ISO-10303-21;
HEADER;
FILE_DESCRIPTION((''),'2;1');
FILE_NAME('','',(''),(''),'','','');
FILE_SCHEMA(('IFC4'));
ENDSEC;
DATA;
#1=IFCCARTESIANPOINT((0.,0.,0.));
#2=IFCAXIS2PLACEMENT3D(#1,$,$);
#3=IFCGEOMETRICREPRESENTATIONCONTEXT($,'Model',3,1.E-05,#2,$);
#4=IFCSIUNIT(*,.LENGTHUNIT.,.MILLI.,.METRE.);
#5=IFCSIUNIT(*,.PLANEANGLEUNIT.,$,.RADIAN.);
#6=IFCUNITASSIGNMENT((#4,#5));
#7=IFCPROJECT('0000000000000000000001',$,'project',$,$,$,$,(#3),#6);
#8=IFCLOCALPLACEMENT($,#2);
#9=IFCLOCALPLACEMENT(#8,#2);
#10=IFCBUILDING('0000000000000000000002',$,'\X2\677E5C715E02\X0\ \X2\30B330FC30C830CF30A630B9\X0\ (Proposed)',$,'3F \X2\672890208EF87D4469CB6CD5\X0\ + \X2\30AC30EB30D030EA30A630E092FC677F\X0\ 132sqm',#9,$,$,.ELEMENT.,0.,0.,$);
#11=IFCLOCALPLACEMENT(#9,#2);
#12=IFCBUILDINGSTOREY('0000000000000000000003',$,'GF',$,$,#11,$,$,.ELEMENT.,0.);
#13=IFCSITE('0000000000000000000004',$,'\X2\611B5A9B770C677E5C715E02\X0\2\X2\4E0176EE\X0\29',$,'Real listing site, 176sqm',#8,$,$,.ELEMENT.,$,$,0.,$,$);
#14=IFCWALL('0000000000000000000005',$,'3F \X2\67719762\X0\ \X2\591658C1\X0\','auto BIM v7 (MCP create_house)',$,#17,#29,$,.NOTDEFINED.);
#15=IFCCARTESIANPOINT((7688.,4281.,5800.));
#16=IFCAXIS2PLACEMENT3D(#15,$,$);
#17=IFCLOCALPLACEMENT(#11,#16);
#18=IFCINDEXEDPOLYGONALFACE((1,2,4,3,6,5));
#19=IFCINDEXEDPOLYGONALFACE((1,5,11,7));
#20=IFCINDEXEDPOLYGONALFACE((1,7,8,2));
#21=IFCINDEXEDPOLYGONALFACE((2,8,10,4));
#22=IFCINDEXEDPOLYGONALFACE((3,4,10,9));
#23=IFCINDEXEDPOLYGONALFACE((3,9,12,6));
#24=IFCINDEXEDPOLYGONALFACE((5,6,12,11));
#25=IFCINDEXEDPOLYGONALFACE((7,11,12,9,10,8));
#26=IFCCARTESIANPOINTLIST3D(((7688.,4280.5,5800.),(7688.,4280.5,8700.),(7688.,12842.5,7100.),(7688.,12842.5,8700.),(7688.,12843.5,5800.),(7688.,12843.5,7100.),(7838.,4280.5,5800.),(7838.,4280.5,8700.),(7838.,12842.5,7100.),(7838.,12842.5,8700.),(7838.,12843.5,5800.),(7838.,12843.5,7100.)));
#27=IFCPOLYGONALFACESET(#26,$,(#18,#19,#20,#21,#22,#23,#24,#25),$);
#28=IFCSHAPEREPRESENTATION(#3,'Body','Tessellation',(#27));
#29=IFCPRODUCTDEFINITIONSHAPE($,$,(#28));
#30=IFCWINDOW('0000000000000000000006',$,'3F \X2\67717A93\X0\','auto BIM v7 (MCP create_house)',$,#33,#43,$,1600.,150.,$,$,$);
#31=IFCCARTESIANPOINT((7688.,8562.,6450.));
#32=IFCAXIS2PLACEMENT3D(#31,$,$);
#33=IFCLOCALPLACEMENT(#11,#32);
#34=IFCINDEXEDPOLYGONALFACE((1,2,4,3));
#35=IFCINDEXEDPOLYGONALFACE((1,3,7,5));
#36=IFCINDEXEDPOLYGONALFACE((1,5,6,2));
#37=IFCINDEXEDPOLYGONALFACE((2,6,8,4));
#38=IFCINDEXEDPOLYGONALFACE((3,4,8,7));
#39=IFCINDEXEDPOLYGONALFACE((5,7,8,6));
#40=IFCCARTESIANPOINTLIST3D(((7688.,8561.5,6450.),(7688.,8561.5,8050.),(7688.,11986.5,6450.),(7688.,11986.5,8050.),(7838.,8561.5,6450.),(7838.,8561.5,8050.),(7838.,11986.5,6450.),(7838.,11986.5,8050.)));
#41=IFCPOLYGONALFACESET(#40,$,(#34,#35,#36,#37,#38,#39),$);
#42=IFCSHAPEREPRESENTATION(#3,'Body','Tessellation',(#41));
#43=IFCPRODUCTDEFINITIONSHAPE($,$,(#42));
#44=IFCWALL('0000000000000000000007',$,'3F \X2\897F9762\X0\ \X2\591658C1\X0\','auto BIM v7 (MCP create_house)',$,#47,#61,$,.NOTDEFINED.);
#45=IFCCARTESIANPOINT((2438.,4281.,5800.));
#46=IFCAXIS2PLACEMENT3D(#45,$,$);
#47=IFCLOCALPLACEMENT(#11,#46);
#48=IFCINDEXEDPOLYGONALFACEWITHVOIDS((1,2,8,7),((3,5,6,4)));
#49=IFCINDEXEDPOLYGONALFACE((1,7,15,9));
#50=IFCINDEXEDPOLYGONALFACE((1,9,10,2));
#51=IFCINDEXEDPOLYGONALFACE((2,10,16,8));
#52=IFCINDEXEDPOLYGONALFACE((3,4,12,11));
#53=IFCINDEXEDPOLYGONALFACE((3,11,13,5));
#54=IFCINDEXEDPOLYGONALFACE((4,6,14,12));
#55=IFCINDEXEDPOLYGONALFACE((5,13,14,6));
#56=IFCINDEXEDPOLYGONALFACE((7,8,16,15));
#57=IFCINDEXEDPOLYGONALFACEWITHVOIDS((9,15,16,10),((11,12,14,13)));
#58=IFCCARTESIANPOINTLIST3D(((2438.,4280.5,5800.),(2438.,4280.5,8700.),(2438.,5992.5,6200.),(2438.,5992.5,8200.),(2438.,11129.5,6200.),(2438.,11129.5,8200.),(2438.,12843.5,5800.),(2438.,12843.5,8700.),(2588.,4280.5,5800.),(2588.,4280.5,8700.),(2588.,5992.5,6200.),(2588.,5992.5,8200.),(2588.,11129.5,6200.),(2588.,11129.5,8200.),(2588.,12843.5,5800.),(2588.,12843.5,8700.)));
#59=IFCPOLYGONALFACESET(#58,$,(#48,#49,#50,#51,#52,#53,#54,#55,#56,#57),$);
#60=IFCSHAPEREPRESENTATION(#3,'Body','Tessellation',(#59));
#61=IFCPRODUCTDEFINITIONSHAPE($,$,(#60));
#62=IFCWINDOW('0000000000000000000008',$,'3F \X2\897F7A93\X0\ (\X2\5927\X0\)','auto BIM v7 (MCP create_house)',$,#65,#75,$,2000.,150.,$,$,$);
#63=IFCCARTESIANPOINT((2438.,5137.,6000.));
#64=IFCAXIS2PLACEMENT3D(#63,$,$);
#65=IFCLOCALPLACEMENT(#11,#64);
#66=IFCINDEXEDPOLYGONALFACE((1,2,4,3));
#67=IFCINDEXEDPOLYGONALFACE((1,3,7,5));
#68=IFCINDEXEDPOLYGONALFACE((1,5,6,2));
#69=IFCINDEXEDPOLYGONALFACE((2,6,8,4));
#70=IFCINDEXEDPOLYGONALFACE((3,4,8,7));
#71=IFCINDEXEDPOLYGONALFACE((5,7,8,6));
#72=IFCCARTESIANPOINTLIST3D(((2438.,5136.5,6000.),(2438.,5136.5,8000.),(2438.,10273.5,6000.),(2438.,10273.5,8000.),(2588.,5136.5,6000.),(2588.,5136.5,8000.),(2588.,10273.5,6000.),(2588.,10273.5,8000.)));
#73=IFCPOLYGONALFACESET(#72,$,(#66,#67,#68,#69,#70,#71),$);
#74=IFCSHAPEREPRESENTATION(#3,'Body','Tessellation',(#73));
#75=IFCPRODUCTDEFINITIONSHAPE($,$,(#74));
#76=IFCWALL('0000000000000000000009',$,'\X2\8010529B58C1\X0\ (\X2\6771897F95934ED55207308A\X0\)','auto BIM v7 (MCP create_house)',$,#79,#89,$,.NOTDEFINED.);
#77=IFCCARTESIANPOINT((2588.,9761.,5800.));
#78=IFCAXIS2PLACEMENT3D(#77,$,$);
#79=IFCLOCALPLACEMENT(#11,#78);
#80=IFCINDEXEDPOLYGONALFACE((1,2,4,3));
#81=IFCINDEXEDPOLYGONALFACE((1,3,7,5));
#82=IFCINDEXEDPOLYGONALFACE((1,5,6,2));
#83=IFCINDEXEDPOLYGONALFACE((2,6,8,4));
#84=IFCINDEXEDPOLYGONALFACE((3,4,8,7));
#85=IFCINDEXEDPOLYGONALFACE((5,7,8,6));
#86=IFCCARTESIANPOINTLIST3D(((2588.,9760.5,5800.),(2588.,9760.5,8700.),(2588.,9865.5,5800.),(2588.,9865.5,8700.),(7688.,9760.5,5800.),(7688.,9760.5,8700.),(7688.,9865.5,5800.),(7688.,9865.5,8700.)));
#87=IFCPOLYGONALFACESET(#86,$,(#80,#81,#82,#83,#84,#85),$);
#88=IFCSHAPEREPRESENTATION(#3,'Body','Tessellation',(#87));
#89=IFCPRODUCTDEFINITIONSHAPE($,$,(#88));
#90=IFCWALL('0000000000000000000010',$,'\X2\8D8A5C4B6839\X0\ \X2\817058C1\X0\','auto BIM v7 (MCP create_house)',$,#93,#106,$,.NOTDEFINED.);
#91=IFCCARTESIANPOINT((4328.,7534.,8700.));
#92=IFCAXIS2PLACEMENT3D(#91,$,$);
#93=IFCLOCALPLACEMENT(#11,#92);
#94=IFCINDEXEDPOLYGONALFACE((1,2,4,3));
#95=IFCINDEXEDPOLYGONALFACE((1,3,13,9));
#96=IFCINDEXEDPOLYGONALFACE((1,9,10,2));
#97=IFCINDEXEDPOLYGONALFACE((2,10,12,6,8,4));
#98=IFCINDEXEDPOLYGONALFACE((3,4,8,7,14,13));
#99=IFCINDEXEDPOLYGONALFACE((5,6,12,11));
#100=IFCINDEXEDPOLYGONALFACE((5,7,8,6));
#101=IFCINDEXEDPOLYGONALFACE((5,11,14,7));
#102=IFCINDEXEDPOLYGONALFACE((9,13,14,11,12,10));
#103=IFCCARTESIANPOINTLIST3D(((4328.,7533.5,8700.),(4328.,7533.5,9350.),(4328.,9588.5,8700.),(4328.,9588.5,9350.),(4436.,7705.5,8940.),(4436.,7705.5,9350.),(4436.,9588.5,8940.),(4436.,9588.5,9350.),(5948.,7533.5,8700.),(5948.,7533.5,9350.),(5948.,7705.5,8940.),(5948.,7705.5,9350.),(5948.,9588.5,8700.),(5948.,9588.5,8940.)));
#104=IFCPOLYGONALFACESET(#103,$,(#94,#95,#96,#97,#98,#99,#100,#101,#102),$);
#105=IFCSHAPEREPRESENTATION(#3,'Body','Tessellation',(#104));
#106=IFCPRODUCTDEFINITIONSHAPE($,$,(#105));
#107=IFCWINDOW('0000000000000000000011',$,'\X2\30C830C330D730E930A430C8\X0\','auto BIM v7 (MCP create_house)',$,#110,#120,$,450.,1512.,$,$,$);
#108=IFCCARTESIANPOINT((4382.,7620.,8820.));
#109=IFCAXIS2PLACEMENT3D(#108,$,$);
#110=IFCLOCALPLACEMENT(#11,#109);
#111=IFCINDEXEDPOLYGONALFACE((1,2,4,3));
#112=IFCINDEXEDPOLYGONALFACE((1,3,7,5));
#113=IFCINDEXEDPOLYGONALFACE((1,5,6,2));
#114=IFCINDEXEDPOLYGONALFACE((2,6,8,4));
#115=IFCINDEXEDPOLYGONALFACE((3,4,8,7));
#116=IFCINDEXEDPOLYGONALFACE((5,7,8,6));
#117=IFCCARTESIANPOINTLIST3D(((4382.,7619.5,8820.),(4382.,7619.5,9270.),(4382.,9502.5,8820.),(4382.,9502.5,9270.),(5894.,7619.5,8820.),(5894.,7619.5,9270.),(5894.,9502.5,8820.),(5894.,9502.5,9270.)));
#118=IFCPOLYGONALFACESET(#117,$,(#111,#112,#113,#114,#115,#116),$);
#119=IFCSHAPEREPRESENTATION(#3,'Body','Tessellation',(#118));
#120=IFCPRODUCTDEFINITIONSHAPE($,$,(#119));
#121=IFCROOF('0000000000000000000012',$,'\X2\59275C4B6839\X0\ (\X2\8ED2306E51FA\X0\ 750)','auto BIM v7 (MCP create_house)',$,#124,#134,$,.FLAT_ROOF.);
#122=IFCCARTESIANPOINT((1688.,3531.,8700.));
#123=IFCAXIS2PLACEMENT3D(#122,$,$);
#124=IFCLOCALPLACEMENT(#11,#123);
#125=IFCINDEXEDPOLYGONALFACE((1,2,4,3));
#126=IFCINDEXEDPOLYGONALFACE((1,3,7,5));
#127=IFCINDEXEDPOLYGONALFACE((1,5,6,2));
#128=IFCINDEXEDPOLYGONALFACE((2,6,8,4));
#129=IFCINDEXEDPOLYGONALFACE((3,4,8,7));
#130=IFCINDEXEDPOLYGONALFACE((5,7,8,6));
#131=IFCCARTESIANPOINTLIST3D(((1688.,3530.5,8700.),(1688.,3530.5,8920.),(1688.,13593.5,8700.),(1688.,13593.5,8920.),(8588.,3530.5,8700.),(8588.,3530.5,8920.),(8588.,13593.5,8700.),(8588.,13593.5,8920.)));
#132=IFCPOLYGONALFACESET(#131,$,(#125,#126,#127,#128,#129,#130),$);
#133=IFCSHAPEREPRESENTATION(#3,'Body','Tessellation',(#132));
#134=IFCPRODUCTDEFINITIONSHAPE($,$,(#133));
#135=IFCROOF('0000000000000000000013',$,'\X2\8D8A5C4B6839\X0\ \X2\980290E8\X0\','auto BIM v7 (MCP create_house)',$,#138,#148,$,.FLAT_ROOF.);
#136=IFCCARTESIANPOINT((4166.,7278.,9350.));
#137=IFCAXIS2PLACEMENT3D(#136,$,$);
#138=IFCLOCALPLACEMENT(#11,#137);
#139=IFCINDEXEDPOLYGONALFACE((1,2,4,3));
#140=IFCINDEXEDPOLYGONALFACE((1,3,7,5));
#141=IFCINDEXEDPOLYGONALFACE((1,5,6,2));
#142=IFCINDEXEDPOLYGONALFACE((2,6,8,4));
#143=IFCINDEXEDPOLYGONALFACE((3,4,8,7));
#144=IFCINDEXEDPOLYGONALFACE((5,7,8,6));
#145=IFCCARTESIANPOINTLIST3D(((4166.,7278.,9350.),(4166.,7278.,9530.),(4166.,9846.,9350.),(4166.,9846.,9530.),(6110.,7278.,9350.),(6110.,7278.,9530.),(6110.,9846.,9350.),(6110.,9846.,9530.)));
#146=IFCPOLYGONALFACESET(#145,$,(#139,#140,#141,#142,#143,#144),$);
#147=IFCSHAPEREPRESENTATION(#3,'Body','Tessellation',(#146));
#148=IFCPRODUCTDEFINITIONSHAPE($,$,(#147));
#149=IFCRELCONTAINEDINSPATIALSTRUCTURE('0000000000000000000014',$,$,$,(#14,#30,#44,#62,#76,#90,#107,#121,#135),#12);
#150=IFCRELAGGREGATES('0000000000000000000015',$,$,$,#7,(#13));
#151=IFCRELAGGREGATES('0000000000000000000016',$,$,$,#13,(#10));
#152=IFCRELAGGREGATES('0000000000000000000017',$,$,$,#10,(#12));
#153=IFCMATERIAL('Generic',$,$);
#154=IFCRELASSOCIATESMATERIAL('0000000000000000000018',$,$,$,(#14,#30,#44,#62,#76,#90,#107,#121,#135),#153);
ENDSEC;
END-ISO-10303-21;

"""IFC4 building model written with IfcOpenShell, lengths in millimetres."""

from ifc_helpers import new_model, si_unit, frame, frame_2d, origin, place, context, project, spatial, rectangle, extrude, material, element, fill, save


model = new_model("IFC4")

# Units and contexts
model_context = context("Model", 3, precision=1e-05, world=origin())
ifc_project = project(units=[si_unit("LENGTHUNIT", "METRE", prefix="MILLI"), si_unit("PLANEANGLEUNIT", "RADIAN")], contexts=[model_context])

# Site, building, storey
site_placement = place(None, origin())
site = spatial("IfcSite", under=ifc_project, at=site_placement, Name="愛媛県松山市2丁目29", ObjectType="Real listing site, 176sqm", CompositionType="ELEMENT", RefElevation=0.0)
building_placement = place(site_placement, origin())
building = spatial("IfcBuilding", under=site, at=building_placement, Name="松山市 コートハウス (Proposed)", ObjectType="3F 木造軸組構法 + ガルバリウム鋼板 132sqm", CompositionType="ELEMENT", ElevationOfRefHeight=0.0, ElevationOfTerrain=0.0)
storey_placement = place(building_placement, origin())
storey = spatial("IfcBuildingStorey", under=building, at=storey_placement, Name="GF", CompositionType="ELEMENT", Elevation=0.0)

# Shared definitions
ifc_material = material(Name="Generic")

# Walls, openings, windows
wall_1_placement = place(storey_placement, frame((7688.0, 4281.0, 5800.0)))
wall_1 = element("IfcWall", 1, at=wall_1_placement, inside=storey, material=ifc_material, Name="3F 東面 外壁", Description="auto BIM v7 (MCP create_house)", PredefinedType="NOTDEFINED", context=model_context, shape_type="SweptSolid", body=[
    extrude(rectangle(XDim=150.0, YDim=8563.0, at=frame_2d((75.0, 4281.0))), frame((7688.0, 4281.0, 5800.0)), (0.0, 0.0, 1.0), 2900.0),
])
opening_1_placement = place(storey_placement, frame((7688.0, 8562.0, 6450.0)))
opening_1 = element("IfcOpeningElement", 2, at=opening_1_placement, cuts=wall_1, PredefinedType="NOTDEFINED", context=model_context, shape_type="SweptSolid", body=[
    extrude(rectangle(XDim=150.0, YDim=3425.0, at=frame_2d((75.0, 1712.0))), frame((7688.0, 8562.0, 6450.0)), (0.0, 0.0, 1.0), 1600.0),
])
window_1_placement = place(storey_placement, frame((7688.0, 8562.0, 6450.0)))
window_1 = element("IfcWindow", 3, at=window_1_placement, inside=storey, material=ifc_material, Name="3F 東窓", Description="auto BIM v7 (MCP create_house)", OverallHeight=1600.0, OverallWidth=150.0, context=model_context, shape_type="SweptSolid", body=[
    extrude(rectangle(XDim=150.0, YDim=3425.0, at=frame_2d((75.0, 1712.0))), frame((7688.0, 8562.0, 6450.0)), (0.0, 0.0, 1.0), 1600.0),
])
fill(opening_1, window_1)
wall_2_placement = place(storey_placement, frame((2438.0, 4281.0, 5800.0)))
wall_2 = element("IfcWall", 4, at=wall_2_placement, inside=storey, material=ifc_material, Name="3F 西面 外壁", Description="auto BIM v7 (MCP create_house)", PredefinedType="NOTDEFINED", context=model_context, shape_type="SweptSolid", body=[
    extrude(rectangle(XDim=150.0, YDim=8563.0, at=frame_2d((75.0, 4281.0))), frame((2438.0, 4281.0, 5800.0)), (0.0, 0.0, 1.0), 2900.0),
])
opening_2_placement = place(storey_placement, frame((2438.0, 5137.0, 6000.0)))
opening_2 = element("IfcOpeningElement", 5, at=opening_2_placement, cuts=wall_2, PredefinedType="NOTDEFINED", context=model_context, shape_type="SweptSolid", body=[
    extrude(rectangle(XDim=150.0, YDim=5137.0, at=frame_2d((75.0, 2568.0))), frame((2438.0, 5137.0, 6000.0)), (0.0, 0.0, 1.0), 2000.0),
])
window_2_placement = place(storey_placement, frame((2438.0, 5137.0, 6000.0)))
window_2 = element("IfcWindow", 6, at=window_2_placement, inside=storey, material=ifc_material, Name="3F 西窓 (大)", Description="auto BIM v7 (MCP create_house)", OverallHeight=2000.0, OverallWidth=150.0, context=model_context, shape_type="SweptSolid", body=[
    extrude(rectangle(XDim=150.0, YDim=5137.0, at=frame_2d((75.0, 2568.0))), frame((2438.0, 5137.0, 6000.0)), (0.0, 0.0, 1.0), 2000.0),
])
fill(opening_2, window_2)

# Wall
wall_3_placement = place(storey_placement, frame((2588.0, 9761.0, 5800.0)))
element("IfcWall", 7, at=wall_3_placement, inside=storey, material=ifc_material, Name="耐力壁 (東西間仕切り)", Description="auto BIM v7 (MCP create_house)", PredefinedType="NOTDEFINED", context=model_context, shape_type="SweptSolid", body=[
    extrude(rectangle(XDim=5100.0, YDim=105.0, at=frame_2d((2550.0, 52.0))), frame((2588.0, 9761.0, 5800.0)), (0.0, 0.0, 1.0), 2900.0),
])

# Wall, opening, window
wall_4_placement = place(storey_placement, frame((4328.0, 7534.0, 8700.0)))
wall_4 = element("IfcWall", 8, at=wall_4_placement, inside=storey, material=ifc_material, Name="越屋根 腰壁", Description="auto BIM v7 (MCP create_house)", PredefinedType="NOTDEFINED", context=model_context, shape_type="SweptSolid", body=[
    extrude(rectangle(XDim=1620.0, YDim=2055.0, at=frame_2d((810.0, 1027.0))), frame((4328.0, 7534.0, 8700.0)), (0.0, 0.0, 1.0), 650.0),
])
opening_3_placement = place(storey_placement, frame((4382.0, 7620.0, 8820.0)))
opening_3 = element("IfcOpeningElement", 9, at=opening_3_placement, cuts=wall_4, PredefinedType="NOTDEFINED", context=model_context, shape_type="SweptSolid", body=[
    extrude(rectangle(XDim=1512.0, YDim=1883.0, at=frame_2d((756.0, 941.0))), frame((4382.0, 7620.0, 8820.0)), (0.0, 0.0, 1.0), 450.0),
])
window_3_placement = place(storey_placement, frame((4382.0, 7620.0, 8820.0)))
window_3 = element("IfcWindow", 10, at=window_3_placement, inside=storey, material=ifc_material, Name="トップライト", Description="auto BIM v7 (MCP create_house)", OverallHeight=450.0, OverallWidth=1512.0, context=model_context, shape_type="SweptSolid", body=[
    extrude(rectangle(XDim=1512.0, YDim=1883.0, at=frame_2d((756.0, 941.0))), frame((4382.0, 7620.0, 8820.0)), (0.0, 0.0, 1.0), 450.0),
])
fill(opening_3, window_3)

# Roofs
roof_1_placement = place(storey_placement, frame((1688.0, 3531.0, 8700.0)))
element("IfcRoof", 11, at=roof_1_placement, inside=storey, material=ifc_material, Name="大屋根 (軒の出 750)", Description="auto BIM v7 (MCP create_house)", PredefinedType="FLAT_ROOF", context=model_context, shape_type="SweptSolid", body=[
    extrude(rectangle(XDim=6900.0, YDim=10063.0, at=frame_2d((3450.0, 5031.0))), frame((1688.0, 3531.0, 8700.0)), (0.0, 0.0, 1.0), 220.0),
])
roof_2_placement = place(storey_placement, frame((4166.0, 7278.0, 9350.0)))
element("IfcRoof", 12, at=roof_2_placement, inside=storey, material=ifc_material, Name="越屋根 頂部", Description="auto BIM v7 (MCP create_house)", PredefinedType="FLAT_ROOF", context=model_context, shape_type="SweptSolid", body=[
    extrude(rectangle(XDim=1944.0, YDim=2568.0, at=frame_2d((972.0, 1284.0))), frame((4166.0, 7278.0, 9350.0)), (0.0, 0.0, 1.0), 180.0),
])

save(model, "model.ifc")
